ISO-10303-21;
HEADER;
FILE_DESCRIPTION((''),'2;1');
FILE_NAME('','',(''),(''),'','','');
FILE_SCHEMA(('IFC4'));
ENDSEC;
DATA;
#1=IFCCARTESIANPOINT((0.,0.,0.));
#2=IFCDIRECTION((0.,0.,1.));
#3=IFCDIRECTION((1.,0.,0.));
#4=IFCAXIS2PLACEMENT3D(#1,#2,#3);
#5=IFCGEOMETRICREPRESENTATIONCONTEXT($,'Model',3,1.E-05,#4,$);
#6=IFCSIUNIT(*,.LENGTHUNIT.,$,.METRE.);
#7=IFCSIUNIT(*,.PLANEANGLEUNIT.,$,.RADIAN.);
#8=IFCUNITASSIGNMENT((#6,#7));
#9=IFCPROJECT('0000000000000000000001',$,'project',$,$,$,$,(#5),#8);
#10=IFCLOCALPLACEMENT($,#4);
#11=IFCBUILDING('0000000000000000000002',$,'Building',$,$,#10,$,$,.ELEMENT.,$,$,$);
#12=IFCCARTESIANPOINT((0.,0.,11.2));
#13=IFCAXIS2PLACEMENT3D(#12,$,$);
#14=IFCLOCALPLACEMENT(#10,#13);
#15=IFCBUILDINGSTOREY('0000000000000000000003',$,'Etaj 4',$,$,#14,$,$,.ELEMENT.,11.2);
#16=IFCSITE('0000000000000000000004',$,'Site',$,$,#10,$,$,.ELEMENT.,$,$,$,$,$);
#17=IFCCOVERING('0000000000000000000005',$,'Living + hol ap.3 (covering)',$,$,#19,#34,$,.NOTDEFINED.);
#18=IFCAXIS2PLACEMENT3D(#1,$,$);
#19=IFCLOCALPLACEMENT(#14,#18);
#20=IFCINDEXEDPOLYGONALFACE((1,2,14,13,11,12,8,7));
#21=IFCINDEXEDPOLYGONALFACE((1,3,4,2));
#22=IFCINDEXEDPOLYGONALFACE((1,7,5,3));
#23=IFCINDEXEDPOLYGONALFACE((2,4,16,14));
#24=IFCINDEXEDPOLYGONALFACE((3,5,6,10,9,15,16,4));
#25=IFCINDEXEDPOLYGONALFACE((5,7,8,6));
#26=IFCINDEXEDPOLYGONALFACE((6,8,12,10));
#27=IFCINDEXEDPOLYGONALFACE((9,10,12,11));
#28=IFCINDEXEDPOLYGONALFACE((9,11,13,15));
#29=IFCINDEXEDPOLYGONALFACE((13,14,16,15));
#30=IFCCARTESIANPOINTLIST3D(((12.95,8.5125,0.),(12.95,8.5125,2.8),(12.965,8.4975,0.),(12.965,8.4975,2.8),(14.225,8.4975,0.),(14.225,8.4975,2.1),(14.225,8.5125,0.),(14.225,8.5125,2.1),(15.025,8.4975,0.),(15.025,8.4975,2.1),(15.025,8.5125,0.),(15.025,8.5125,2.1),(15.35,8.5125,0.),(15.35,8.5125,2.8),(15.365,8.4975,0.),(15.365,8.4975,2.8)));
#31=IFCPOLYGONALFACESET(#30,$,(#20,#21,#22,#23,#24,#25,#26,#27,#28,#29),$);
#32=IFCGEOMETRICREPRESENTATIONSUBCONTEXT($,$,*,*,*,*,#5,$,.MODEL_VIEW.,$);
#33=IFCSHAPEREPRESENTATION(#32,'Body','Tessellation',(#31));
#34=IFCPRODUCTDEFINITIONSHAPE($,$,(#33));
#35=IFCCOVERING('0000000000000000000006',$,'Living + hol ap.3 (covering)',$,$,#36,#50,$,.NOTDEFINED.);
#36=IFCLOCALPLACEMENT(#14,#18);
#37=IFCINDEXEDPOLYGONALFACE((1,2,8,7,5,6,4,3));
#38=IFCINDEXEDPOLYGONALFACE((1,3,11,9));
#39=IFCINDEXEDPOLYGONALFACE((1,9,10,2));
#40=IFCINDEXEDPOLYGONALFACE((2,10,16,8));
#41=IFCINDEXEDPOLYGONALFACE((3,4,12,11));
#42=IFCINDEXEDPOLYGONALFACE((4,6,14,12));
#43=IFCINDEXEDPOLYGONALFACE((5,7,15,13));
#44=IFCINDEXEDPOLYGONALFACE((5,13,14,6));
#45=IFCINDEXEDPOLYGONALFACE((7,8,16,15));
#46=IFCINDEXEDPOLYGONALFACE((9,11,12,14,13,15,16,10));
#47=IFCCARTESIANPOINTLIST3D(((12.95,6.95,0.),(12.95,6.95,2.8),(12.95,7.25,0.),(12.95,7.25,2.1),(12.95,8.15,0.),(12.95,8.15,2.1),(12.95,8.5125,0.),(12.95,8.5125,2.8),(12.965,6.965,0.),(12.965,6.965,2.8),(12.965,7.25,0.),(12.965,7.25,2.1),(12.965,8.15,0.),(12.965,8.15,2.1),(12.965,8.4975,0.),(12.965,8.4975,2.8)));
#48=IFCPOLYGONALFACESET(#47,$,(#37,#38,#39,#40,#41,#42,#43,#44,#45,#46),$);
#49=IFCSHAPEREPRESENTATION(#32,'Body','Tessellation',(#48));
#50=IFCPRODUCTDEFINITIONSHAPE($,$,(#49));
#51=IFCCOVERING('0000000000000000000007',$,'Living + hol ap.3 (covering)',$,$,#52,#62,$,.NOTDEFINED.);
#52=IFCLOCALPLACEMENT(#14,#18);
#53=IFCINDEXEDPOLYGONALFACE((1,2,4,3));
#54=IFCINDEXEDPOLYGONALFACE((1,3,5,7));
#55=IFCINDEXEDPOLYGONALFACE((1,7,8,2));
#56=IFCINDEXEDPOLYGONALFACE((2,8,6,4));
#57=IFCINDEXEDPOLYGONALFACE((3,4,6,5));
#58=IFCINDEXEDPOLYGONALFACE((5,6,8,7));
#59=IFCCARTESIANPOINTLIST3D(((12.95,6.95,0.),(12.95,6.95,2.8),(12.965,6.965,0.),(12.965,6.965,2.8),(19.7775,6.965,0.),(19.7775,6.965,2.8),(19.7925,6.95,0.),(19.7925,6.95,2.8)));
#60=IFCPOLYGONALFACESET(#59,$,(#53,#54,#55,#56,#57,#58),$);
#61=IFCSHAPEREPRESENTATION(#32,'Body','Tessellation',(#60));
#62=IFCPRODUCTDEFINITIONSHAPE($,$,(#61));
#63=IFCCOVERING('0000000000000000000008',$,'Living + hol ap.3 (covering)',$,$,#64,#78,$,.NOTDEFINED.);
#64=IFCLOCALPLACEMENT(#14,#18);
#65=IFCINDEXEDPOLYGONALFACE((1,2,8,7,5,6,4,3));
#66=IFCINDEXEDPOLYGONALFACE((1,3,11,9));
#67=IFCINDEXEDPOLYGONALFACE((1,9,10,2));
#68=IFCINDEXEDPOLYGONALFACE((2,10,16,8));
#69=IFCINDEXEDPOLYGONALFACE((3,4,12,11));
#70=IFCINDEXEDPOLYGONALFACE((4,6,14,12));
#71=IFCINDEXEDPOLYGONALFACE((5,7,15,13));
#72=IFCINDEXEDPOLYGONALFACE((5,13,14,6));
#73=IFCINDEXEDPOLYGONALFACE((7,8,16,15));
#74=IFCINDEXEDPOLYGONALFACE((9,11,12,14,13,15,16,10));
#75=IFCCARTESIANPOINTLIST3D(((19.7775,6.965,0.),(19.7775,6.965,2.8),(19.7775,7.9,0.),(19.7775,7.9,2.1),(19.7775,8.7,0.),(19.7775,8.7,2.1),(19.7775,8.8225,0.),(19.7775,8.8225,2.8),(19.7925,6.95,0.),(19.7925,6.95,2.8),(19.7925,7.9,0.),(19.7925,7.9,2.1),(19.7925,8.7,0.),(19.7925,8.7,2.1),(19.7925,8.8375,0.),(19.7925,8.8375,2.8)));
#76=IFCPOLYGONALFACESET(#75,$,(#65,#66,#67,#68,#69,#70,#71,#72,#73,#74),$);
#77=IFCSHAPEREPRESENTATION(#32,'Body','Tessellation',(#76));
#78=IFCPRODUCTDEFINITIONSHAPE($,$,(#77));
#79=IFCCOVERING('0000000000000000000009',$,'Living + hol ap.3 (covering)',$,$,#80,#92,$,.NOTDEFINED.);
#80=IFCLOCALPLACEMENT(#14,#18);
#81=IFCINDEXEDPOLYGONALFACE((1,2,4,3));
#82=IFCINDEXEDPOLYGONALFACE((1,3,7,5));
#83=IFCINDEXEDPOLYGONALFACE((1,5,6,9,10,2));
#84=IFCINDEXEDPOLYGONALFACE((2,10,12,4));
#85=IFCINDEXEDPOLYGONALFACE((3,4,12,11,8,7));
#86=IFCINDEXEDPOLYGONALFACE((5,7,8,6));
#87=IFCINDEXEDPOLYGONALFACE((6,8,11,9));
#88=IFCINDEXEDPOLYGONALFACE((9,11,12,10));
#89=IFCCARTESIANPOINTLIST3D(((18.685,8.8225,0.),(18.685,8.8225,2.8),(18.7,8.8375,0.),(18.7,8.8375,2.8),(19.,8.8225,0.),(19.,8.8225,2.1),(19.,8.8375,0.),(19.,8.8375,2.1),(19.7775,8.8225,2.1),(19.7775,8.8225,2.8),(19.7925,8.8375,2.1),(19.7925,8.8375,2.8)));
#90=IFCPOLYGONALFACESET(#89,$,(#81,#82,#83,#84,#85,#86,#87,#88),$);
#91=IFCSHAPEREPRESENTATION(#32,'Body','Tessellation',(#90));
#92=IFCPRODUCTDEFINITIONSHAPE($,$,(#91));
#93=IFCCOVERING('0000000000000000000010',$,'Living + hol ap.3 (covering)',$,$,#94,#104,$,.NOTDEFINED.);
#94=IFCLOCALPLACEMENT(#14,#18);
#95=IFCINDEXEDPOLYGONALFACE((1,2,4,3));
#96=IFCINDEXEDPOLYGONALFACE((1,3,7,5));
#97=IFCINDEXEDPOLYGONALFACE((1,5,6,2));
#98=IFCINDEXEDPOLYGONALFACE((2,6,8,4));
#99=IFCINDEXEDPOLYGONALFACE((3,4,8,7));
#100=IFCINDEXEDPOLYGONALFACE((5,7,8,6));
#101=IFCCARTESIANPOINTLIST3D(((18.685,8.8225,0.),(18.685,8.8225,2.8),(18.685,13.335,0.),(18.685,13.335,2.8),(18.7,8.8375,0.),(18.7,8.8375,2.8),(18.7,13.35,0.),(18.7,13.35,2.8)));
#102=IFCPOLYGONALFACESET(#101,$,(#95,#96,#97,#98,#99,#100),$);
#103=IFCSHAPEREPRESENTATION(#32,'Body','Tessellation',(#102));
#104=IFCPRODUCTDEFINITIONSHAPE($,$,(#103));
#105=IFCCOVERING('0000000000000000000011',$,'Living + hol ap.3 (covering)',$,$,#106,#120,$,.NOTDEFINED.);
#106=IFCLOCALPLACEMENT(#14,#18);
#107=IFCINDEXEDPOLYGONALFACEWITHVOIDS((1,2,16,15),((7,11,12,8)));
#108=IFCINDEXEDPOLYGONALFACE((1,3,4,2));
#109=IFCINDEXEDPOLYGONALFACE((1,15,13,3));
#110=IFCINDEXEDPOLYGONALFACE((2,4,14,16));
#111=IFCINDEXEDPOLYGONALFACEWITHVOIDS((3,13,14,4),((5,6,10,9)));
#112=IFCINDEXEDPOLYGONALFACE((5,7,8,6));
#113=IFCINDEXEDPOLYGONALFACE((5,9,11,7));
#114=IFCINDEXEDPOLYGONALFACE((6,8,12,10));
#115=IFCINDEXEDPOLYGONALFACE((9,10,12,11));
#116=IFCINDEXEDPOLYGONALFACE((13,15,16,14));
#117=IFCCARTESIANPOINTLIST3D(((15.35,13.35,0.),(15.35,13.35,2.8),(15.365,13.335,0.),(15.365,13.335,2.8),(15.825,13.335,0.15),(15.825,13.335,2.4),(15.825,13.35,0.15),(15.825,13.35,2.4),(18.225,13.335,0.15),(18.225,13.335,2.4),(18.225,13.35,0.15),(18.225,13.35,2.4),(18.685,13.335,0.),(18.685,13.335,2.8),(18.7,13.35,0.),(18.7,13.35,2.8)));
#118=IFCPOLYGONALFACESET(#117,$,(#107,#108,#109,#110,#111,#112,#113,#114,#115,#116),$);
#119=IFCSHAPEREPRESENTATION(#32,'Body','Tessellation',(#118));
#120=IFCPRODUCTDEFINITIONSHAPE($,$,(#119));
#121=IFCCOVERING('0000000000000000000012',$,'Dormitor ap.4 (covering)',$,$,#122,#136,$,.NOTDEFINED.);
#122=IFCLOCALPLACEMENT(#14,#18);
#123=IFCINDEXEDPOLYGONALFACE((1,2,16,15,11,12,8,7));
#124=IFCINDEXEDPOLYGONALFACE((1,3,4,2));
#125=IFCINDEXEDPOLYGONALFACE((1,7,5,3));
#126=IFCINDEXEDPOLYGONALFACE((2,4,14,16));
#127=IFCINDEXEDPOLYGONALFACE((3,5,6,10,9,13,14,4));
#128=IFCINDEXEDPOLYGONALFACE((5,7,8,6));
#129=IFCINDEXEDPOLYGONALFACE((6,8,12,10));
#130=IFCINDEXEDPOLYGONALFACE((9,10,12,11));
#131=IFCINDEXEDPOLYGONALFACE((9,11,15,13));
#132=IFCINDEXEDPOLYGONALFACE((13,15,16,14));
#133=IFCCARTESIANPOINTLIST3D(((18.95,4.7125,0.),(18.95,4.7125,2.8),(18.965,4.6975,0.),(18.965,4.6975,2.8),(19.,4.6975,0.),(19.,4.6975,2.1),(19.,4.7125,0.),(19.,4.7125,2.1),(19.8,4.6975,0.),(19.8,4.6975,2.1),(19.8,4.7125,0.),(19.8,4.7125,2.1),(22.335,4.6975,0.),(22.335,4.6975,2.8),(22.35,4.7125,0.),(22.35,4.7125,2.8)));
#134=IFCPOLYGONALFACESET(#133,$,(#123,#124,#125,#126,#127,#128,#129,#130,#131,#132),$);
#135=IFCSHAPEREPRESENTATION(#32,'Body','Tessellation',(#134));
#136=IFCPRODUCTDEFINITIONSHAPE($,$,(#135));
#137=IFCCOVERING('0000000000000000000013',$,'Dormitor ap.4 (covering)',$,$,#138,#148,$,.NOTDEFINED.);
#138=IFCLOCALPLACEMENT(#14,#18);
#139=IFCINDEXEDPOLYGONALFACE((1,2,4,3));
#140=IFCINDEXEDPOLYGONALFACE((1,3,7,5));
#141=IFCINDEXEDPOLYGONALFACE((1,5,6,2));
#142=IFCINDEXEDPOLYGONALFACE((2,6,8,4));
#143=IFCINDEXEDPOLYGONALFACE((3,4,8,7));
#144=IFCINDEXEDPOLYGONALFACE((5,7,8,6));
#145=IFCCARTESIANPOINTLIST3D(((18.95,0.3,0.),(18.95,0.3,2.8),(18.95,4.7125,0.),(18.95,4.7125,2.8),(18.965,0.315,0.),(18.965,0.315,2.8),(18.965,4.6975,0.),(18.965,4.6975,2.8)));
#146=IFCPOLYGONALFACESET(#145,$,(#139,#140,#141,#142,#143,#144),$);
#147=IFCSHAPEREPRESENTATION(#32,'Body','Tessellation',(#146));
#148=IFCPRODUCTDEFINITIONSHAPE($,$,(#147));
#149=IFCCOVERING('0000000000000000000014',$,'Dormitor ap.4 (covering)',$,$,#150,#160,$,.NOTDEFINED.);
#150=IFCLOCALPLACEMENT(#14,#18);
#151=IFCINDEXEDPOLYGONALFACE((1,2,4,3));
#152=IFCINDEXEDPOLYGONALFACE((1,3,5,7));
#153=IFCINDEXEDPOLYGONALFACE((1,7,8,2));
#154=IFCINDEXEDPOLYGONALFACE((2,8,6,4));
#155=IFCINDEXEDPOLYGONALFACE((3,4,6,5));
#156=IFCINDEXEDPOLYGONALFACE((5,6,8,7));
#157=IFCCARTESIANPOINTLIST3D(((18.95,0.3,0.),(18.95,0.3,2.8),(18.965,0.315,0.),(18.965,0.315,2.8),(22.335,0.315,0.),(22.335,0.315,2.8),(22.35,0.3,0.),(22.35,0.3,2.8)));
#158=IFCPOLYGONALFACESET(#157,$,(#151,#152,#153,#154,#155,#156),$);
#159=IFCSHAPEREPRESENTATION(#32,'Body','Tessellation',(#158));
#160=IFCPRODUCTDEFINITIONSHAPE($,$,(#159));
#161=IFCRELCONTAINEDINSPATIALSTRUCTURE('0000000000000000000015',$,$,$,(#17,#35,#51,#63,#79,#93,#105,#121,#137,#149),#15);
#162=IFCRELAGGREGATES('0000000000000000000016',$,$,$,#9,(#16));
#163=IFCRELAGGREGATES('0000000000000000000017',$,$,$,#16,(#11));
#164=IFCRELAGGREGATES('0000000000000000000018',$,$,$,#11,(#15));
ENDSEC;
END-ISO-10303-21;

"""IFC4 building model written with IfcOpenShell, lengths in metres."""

from ifc_helpers import new_model, si_unit, frame, origin, origin_with_axes, origin_2d, place, context, subcontext, project, spatial, polyline, rectangle, outline, extrude, element, save


model = new_model("IFC4")

# Units and contexts
model_context = context("Model", 3, precision=1e-05, world=origin_with_axes())
sub_context = subcontext(model_context, None, None, "MODEL_VIEW")
ifc_project = project(units=[si_unit("LENGTHUNIT", "METRE"), si_unit("PLANEANGLEUNIT", "RADIAN")], contexts=[model_context])

# Site, building, storey
placement = place(None, origin_with_axes())
site = spatial("IfcSite", under=ifc_project, at=placement, Name="Site", CompositionType="ELEMENT")
building = spatial("IfcBuilding", under=site, at=placement, Name="Building", CompositionType="ELEMENT")
storey_placement = place(placement, frame((0.0, 0.0, 11.2)))
storey = spatial("IfcBuildingStorey", under=building, at=storey_placement, Name="Etaj 4", CompositionType="ELEMENT", Elevation=11.2)

# Coverings, openings
covering_1_placement = place(storey_placement, origin_with_axes())
covering_1 = element("IfcCovering", 1, at=covering_1_placement, inside=storey, Name="Living + hol ap.3 (covering)", PredefinedType="NOTDEFINED", context=sub_context, shape_type="SweptSolid", body=[
    extrude(outline(polyline([(15.35, 8.5125), (12.95, 8.5125), (12.965, 8.4975), (15.365, 8.4975), (15.35, 8.5125)])), origin(), (0.0, 0.0, 1.0), 2.8),
])
opening_1_placement = place(covering_1_placement, frame((14.625, 8.8275, 0.0), z_axis=(0.0, -1.0, 0.0), x_axis=(1.0, 0.0, 0.0)))
element("IfcOpeningElement", 2, at=opening_1_placement, cuts=covering_1, PredefinedType="OPENING", context=sub_context, shape_type="SweptSolid", body=[
    extrude(rectangle(XDim=0.8, YDim=2.1, at=origin_2d()), frame((0.0, 1.05, 0.0)), (0.0, 0.0, 1.0), 0.38),
])
covering_2_placement = place(storey_placement, origin_with_axes())
covering_2 = element("IfcCovering", 3, at=covering_2_placement, inside=storey, Name="Living + hol ap.3 (covering)", PredefinedType="NOTDEFINED", context=sub_context, shape_type="SweptSolid", body=[
    extrude(outline(polyline([(12.95, 8.5125), (12.95, 6.95), (12.965, 6.965), (12.965, 8.4975), (12.95, 8.5125)])), origin(), (0.0, 0.0, 1.0), 2.8),
])
opening_2_placement = place(covering_2_placement, frame((12.635, 7.7, 0.0), z_axis=(1.0, 0.0, 0.0), x_axis=(0.0, 1.0, 0.0)))
element("IfcOpeningElement", 4, at=opening_2_placement, cuts=covering_2, PredefinedType="OPENING", context=sub_context, shape_type="SweptSolid", body=[
    extrude(rectangle(XDim=0.9, YDim=2.1, at=origin_2d()), frame((0.0, 1.05, 0.0)), (0.0, 0.0, 1.0), 0.38),
])

# Covering
covering_3_placement = place(storey_placement, origin_with_axes())
element("IfcCovering", 5, at=covering_3_placement, inside=storey, Name="Living + hol ap.3 (covering)", PredefinedType="NOTDEFINED", context=sub_context, shape_type="SweptSolid", body=[
    extrude(outline(polyline([(12.95, 6.95), (19.7925, 6.95), (19.7775, 6.965), (12.965, 6.965), (12.95, 6.95)])), origin(), (0.0, 0.0, 1.0), 2.8),
])

# Coverings, openings
covering_4_placement = place(storey_placement, origin_with_axes())
covering_4 = element("IfcCovering", 6, at=covering_4_placement, inside=storey, Name="Living + hol ap.3 (covering)", PredefinedType="NOTDEFINED", context=sub_context, shape_type="SweptSolid", body=[
    extrude(outline(polyline([(19.7925, 6.95), (19.7925, 8.8375), (19.7775, 8.8225), (19.7775, 6.965), (19.7925, 6.95)])), origin(), (0.0, 0.0, 1.0), 2.8),
])
opening_3_placement = place(covering_4_placement, frame((19.7275, 8.3, 0.0), z_axis=(1.0, 0.0, 0.0), x_axis=(0.0, 1.0, 0.0)))
element("IfcOpeningElement", 7, at=opening_3_placement, cuts=covering_4, PredefinedType="OPENING", context=sub_context, shape_type="SweptSolid", body=[
    extrude(rectangle(XDim=0.8, YDim=2.1, at=origin_2d()), frame((0.0, 1.05, 0.0)), (0.0, 0.0, 1.0), 0.38),
])
covering_5_placement = place(storey_placement, origin_with_axes())
covering_5 = element("IfcCovering", 8, at=covering_5_placement, inside=storey, Name="Living + hol ap.3 (covering)", PredefinedType="NOTDEFINED", context=sub_context, shape_type="SweptSolid", body=[
    extrude(outline(polyline([(19.7925, 8.8375), (18.7, 8.8375), (18.685, 8.8225), (19.7775, 8.8225), (19.7925, 8.8375)])), origin(), (0.0, 0.0, 1.0), 2.8),
])
opening_4_placement = place(covering_5_placement, frame((19.4, 9.1525, 0.0), z_axis=(0.0, -1.0, 0.0), x_axis=(1.0, 0.0, 0.0)))
element("IfcOpeningElement", 9, at=opening_4_placement, cuts=covering_5, PredefinedType="OPENING", context=sub_context, shape_type="SweptSolid", body=[
    extrude(rectangle(XDim=0.8, YDim=2.1, at=origin_2d()), frame((0.0, 1.05, 0.0)), (0.0, 0.0, 1.0), 0.38),
])

# Covering
covering_6_placement = place(storey_placement, origin_with_axes())
element("IfcCovering", 10, at=covering_6_placement, inside=storey, Name="Living + hol ap.3 (covering)", PredefinedType="NOTDEFINED", context=sub_context, shape_type="SweptSolid", body=[
    extrude(outline(polyline([(18.7, 8.8375), (18.7, 13.35), (18.685, 13.335), (18.685, 8.8225), (18.7, 8.8375)])), origin(), (0.0, 0.0, 1.0), 2.8),
])

# Coverings, openings
covering_7_placement = place(storey_placement, origin_with_axes())
covering_7 = element("IfcCovering", 11, at=covering_7_placement, inside=storey, Name="Living + hol ap.3 (covering)", PredefinedType="NOTDEFINED", context=sub_context, shape_type="SweptSolid", body=[
    extrude(outline(polyline([(18.7, 13.35), (15.35, 13.35), (15.365, 13.335), (18.685, 13.335), (18.7, 13.35)])), origin(), (0.0, 0.0, 1.0), 2.8),
])
opening_5_placement = place(covering_7_placement, frame((17.025, 13.665, 0.15), z_axis=(0.0, -1.0, 0.0), x_axis=(1.0, 0.0, 0.0)))
element("IfcOpeningElement", 12, at=opening_5_placement, cuts=covering_7, PredefinedType="OPENING", context=sub_context, shape_type="SweptSolid", body=[
    extrude(rectangle(XDim=2.4, YDim=2.25, at=origin_2d()), frame((0.0, 1.125, 0.0)), (0.0, 0.0, 1.0), 0.38),
])
covering_8_placement = place(storey_placement, origin_with_axes())
covering_8 = element("IfcCovering", 13, at=covering_8_placement, inside=storey, Name="Dormitor ap.4 (covering)", PredefinedType="NOTDEFINED", context=sub_context, shape_type="SweptSolid", body=[
    extrude(outline(polyline([(22.35, 4.7125), (18.95, 4.7125), (18.965, 4.6975), (22.335, 4.6975), (22.35, 4.7125)])), origin(), (0.0, 0.0, 1.0), 2.8),
])
opening_6_placement = place(covering_8_placement, frame((19.4, 5.0275, 0.0), z_axis=(0.0, -1.0, 0.0), x_axis=(1.0, 0.0, 0.0)))
element("IfcOpeningElement", 14, at=opening_6_placement, cuts=covering_8, PredefinedType="OPENING", context=sub_context, shape_type="SweptSolid", body=[
    extrude(rectangle(XDim=0.8, YDim=2.1, at=origin_2d()), frame((0.0, 1.05, 0.0)), (0.0, 0.0, 1.0), 0.38),
])

# Coverings
covering_9_placement = place(storey_placement, origin_with_axes())
element("IfcCovering", 15, at=covering_9_placement, inside=storey, Name="Dormitor ap.4 (covering)", PredefinedType="NOTDEFINED", context=sub_context, shape_type="SweptSolid", body=[
    extrude(outline(polyline([(18.95, 4.7125), (18.95, 0.3), (18.965, 0.315), (18.965, 4.6975), (18.95, 4.7125)])), origin(), (0.0, 0.0, 1.0), 2.8),
])
covering_10_placement = place(storey_placement, origin_with_axes())
element("IfcCovering", 16, at=covering_10_placement, inside=storey, Name="Dormitor ap.4 (covering)", PredefinedType="NOTDEFINED", context=sub_context, shape_type="SweptSolid", body=[
    extrude(outline(polyline([(18.95, 0.3), (22.35, 0.3), (22.335, 0.315), (18.965, 0.315), (18.95, 0.3)])), origin(), (0.0, 0.0, 1.0), 2.8),
])

save(model, "model.ifc")
